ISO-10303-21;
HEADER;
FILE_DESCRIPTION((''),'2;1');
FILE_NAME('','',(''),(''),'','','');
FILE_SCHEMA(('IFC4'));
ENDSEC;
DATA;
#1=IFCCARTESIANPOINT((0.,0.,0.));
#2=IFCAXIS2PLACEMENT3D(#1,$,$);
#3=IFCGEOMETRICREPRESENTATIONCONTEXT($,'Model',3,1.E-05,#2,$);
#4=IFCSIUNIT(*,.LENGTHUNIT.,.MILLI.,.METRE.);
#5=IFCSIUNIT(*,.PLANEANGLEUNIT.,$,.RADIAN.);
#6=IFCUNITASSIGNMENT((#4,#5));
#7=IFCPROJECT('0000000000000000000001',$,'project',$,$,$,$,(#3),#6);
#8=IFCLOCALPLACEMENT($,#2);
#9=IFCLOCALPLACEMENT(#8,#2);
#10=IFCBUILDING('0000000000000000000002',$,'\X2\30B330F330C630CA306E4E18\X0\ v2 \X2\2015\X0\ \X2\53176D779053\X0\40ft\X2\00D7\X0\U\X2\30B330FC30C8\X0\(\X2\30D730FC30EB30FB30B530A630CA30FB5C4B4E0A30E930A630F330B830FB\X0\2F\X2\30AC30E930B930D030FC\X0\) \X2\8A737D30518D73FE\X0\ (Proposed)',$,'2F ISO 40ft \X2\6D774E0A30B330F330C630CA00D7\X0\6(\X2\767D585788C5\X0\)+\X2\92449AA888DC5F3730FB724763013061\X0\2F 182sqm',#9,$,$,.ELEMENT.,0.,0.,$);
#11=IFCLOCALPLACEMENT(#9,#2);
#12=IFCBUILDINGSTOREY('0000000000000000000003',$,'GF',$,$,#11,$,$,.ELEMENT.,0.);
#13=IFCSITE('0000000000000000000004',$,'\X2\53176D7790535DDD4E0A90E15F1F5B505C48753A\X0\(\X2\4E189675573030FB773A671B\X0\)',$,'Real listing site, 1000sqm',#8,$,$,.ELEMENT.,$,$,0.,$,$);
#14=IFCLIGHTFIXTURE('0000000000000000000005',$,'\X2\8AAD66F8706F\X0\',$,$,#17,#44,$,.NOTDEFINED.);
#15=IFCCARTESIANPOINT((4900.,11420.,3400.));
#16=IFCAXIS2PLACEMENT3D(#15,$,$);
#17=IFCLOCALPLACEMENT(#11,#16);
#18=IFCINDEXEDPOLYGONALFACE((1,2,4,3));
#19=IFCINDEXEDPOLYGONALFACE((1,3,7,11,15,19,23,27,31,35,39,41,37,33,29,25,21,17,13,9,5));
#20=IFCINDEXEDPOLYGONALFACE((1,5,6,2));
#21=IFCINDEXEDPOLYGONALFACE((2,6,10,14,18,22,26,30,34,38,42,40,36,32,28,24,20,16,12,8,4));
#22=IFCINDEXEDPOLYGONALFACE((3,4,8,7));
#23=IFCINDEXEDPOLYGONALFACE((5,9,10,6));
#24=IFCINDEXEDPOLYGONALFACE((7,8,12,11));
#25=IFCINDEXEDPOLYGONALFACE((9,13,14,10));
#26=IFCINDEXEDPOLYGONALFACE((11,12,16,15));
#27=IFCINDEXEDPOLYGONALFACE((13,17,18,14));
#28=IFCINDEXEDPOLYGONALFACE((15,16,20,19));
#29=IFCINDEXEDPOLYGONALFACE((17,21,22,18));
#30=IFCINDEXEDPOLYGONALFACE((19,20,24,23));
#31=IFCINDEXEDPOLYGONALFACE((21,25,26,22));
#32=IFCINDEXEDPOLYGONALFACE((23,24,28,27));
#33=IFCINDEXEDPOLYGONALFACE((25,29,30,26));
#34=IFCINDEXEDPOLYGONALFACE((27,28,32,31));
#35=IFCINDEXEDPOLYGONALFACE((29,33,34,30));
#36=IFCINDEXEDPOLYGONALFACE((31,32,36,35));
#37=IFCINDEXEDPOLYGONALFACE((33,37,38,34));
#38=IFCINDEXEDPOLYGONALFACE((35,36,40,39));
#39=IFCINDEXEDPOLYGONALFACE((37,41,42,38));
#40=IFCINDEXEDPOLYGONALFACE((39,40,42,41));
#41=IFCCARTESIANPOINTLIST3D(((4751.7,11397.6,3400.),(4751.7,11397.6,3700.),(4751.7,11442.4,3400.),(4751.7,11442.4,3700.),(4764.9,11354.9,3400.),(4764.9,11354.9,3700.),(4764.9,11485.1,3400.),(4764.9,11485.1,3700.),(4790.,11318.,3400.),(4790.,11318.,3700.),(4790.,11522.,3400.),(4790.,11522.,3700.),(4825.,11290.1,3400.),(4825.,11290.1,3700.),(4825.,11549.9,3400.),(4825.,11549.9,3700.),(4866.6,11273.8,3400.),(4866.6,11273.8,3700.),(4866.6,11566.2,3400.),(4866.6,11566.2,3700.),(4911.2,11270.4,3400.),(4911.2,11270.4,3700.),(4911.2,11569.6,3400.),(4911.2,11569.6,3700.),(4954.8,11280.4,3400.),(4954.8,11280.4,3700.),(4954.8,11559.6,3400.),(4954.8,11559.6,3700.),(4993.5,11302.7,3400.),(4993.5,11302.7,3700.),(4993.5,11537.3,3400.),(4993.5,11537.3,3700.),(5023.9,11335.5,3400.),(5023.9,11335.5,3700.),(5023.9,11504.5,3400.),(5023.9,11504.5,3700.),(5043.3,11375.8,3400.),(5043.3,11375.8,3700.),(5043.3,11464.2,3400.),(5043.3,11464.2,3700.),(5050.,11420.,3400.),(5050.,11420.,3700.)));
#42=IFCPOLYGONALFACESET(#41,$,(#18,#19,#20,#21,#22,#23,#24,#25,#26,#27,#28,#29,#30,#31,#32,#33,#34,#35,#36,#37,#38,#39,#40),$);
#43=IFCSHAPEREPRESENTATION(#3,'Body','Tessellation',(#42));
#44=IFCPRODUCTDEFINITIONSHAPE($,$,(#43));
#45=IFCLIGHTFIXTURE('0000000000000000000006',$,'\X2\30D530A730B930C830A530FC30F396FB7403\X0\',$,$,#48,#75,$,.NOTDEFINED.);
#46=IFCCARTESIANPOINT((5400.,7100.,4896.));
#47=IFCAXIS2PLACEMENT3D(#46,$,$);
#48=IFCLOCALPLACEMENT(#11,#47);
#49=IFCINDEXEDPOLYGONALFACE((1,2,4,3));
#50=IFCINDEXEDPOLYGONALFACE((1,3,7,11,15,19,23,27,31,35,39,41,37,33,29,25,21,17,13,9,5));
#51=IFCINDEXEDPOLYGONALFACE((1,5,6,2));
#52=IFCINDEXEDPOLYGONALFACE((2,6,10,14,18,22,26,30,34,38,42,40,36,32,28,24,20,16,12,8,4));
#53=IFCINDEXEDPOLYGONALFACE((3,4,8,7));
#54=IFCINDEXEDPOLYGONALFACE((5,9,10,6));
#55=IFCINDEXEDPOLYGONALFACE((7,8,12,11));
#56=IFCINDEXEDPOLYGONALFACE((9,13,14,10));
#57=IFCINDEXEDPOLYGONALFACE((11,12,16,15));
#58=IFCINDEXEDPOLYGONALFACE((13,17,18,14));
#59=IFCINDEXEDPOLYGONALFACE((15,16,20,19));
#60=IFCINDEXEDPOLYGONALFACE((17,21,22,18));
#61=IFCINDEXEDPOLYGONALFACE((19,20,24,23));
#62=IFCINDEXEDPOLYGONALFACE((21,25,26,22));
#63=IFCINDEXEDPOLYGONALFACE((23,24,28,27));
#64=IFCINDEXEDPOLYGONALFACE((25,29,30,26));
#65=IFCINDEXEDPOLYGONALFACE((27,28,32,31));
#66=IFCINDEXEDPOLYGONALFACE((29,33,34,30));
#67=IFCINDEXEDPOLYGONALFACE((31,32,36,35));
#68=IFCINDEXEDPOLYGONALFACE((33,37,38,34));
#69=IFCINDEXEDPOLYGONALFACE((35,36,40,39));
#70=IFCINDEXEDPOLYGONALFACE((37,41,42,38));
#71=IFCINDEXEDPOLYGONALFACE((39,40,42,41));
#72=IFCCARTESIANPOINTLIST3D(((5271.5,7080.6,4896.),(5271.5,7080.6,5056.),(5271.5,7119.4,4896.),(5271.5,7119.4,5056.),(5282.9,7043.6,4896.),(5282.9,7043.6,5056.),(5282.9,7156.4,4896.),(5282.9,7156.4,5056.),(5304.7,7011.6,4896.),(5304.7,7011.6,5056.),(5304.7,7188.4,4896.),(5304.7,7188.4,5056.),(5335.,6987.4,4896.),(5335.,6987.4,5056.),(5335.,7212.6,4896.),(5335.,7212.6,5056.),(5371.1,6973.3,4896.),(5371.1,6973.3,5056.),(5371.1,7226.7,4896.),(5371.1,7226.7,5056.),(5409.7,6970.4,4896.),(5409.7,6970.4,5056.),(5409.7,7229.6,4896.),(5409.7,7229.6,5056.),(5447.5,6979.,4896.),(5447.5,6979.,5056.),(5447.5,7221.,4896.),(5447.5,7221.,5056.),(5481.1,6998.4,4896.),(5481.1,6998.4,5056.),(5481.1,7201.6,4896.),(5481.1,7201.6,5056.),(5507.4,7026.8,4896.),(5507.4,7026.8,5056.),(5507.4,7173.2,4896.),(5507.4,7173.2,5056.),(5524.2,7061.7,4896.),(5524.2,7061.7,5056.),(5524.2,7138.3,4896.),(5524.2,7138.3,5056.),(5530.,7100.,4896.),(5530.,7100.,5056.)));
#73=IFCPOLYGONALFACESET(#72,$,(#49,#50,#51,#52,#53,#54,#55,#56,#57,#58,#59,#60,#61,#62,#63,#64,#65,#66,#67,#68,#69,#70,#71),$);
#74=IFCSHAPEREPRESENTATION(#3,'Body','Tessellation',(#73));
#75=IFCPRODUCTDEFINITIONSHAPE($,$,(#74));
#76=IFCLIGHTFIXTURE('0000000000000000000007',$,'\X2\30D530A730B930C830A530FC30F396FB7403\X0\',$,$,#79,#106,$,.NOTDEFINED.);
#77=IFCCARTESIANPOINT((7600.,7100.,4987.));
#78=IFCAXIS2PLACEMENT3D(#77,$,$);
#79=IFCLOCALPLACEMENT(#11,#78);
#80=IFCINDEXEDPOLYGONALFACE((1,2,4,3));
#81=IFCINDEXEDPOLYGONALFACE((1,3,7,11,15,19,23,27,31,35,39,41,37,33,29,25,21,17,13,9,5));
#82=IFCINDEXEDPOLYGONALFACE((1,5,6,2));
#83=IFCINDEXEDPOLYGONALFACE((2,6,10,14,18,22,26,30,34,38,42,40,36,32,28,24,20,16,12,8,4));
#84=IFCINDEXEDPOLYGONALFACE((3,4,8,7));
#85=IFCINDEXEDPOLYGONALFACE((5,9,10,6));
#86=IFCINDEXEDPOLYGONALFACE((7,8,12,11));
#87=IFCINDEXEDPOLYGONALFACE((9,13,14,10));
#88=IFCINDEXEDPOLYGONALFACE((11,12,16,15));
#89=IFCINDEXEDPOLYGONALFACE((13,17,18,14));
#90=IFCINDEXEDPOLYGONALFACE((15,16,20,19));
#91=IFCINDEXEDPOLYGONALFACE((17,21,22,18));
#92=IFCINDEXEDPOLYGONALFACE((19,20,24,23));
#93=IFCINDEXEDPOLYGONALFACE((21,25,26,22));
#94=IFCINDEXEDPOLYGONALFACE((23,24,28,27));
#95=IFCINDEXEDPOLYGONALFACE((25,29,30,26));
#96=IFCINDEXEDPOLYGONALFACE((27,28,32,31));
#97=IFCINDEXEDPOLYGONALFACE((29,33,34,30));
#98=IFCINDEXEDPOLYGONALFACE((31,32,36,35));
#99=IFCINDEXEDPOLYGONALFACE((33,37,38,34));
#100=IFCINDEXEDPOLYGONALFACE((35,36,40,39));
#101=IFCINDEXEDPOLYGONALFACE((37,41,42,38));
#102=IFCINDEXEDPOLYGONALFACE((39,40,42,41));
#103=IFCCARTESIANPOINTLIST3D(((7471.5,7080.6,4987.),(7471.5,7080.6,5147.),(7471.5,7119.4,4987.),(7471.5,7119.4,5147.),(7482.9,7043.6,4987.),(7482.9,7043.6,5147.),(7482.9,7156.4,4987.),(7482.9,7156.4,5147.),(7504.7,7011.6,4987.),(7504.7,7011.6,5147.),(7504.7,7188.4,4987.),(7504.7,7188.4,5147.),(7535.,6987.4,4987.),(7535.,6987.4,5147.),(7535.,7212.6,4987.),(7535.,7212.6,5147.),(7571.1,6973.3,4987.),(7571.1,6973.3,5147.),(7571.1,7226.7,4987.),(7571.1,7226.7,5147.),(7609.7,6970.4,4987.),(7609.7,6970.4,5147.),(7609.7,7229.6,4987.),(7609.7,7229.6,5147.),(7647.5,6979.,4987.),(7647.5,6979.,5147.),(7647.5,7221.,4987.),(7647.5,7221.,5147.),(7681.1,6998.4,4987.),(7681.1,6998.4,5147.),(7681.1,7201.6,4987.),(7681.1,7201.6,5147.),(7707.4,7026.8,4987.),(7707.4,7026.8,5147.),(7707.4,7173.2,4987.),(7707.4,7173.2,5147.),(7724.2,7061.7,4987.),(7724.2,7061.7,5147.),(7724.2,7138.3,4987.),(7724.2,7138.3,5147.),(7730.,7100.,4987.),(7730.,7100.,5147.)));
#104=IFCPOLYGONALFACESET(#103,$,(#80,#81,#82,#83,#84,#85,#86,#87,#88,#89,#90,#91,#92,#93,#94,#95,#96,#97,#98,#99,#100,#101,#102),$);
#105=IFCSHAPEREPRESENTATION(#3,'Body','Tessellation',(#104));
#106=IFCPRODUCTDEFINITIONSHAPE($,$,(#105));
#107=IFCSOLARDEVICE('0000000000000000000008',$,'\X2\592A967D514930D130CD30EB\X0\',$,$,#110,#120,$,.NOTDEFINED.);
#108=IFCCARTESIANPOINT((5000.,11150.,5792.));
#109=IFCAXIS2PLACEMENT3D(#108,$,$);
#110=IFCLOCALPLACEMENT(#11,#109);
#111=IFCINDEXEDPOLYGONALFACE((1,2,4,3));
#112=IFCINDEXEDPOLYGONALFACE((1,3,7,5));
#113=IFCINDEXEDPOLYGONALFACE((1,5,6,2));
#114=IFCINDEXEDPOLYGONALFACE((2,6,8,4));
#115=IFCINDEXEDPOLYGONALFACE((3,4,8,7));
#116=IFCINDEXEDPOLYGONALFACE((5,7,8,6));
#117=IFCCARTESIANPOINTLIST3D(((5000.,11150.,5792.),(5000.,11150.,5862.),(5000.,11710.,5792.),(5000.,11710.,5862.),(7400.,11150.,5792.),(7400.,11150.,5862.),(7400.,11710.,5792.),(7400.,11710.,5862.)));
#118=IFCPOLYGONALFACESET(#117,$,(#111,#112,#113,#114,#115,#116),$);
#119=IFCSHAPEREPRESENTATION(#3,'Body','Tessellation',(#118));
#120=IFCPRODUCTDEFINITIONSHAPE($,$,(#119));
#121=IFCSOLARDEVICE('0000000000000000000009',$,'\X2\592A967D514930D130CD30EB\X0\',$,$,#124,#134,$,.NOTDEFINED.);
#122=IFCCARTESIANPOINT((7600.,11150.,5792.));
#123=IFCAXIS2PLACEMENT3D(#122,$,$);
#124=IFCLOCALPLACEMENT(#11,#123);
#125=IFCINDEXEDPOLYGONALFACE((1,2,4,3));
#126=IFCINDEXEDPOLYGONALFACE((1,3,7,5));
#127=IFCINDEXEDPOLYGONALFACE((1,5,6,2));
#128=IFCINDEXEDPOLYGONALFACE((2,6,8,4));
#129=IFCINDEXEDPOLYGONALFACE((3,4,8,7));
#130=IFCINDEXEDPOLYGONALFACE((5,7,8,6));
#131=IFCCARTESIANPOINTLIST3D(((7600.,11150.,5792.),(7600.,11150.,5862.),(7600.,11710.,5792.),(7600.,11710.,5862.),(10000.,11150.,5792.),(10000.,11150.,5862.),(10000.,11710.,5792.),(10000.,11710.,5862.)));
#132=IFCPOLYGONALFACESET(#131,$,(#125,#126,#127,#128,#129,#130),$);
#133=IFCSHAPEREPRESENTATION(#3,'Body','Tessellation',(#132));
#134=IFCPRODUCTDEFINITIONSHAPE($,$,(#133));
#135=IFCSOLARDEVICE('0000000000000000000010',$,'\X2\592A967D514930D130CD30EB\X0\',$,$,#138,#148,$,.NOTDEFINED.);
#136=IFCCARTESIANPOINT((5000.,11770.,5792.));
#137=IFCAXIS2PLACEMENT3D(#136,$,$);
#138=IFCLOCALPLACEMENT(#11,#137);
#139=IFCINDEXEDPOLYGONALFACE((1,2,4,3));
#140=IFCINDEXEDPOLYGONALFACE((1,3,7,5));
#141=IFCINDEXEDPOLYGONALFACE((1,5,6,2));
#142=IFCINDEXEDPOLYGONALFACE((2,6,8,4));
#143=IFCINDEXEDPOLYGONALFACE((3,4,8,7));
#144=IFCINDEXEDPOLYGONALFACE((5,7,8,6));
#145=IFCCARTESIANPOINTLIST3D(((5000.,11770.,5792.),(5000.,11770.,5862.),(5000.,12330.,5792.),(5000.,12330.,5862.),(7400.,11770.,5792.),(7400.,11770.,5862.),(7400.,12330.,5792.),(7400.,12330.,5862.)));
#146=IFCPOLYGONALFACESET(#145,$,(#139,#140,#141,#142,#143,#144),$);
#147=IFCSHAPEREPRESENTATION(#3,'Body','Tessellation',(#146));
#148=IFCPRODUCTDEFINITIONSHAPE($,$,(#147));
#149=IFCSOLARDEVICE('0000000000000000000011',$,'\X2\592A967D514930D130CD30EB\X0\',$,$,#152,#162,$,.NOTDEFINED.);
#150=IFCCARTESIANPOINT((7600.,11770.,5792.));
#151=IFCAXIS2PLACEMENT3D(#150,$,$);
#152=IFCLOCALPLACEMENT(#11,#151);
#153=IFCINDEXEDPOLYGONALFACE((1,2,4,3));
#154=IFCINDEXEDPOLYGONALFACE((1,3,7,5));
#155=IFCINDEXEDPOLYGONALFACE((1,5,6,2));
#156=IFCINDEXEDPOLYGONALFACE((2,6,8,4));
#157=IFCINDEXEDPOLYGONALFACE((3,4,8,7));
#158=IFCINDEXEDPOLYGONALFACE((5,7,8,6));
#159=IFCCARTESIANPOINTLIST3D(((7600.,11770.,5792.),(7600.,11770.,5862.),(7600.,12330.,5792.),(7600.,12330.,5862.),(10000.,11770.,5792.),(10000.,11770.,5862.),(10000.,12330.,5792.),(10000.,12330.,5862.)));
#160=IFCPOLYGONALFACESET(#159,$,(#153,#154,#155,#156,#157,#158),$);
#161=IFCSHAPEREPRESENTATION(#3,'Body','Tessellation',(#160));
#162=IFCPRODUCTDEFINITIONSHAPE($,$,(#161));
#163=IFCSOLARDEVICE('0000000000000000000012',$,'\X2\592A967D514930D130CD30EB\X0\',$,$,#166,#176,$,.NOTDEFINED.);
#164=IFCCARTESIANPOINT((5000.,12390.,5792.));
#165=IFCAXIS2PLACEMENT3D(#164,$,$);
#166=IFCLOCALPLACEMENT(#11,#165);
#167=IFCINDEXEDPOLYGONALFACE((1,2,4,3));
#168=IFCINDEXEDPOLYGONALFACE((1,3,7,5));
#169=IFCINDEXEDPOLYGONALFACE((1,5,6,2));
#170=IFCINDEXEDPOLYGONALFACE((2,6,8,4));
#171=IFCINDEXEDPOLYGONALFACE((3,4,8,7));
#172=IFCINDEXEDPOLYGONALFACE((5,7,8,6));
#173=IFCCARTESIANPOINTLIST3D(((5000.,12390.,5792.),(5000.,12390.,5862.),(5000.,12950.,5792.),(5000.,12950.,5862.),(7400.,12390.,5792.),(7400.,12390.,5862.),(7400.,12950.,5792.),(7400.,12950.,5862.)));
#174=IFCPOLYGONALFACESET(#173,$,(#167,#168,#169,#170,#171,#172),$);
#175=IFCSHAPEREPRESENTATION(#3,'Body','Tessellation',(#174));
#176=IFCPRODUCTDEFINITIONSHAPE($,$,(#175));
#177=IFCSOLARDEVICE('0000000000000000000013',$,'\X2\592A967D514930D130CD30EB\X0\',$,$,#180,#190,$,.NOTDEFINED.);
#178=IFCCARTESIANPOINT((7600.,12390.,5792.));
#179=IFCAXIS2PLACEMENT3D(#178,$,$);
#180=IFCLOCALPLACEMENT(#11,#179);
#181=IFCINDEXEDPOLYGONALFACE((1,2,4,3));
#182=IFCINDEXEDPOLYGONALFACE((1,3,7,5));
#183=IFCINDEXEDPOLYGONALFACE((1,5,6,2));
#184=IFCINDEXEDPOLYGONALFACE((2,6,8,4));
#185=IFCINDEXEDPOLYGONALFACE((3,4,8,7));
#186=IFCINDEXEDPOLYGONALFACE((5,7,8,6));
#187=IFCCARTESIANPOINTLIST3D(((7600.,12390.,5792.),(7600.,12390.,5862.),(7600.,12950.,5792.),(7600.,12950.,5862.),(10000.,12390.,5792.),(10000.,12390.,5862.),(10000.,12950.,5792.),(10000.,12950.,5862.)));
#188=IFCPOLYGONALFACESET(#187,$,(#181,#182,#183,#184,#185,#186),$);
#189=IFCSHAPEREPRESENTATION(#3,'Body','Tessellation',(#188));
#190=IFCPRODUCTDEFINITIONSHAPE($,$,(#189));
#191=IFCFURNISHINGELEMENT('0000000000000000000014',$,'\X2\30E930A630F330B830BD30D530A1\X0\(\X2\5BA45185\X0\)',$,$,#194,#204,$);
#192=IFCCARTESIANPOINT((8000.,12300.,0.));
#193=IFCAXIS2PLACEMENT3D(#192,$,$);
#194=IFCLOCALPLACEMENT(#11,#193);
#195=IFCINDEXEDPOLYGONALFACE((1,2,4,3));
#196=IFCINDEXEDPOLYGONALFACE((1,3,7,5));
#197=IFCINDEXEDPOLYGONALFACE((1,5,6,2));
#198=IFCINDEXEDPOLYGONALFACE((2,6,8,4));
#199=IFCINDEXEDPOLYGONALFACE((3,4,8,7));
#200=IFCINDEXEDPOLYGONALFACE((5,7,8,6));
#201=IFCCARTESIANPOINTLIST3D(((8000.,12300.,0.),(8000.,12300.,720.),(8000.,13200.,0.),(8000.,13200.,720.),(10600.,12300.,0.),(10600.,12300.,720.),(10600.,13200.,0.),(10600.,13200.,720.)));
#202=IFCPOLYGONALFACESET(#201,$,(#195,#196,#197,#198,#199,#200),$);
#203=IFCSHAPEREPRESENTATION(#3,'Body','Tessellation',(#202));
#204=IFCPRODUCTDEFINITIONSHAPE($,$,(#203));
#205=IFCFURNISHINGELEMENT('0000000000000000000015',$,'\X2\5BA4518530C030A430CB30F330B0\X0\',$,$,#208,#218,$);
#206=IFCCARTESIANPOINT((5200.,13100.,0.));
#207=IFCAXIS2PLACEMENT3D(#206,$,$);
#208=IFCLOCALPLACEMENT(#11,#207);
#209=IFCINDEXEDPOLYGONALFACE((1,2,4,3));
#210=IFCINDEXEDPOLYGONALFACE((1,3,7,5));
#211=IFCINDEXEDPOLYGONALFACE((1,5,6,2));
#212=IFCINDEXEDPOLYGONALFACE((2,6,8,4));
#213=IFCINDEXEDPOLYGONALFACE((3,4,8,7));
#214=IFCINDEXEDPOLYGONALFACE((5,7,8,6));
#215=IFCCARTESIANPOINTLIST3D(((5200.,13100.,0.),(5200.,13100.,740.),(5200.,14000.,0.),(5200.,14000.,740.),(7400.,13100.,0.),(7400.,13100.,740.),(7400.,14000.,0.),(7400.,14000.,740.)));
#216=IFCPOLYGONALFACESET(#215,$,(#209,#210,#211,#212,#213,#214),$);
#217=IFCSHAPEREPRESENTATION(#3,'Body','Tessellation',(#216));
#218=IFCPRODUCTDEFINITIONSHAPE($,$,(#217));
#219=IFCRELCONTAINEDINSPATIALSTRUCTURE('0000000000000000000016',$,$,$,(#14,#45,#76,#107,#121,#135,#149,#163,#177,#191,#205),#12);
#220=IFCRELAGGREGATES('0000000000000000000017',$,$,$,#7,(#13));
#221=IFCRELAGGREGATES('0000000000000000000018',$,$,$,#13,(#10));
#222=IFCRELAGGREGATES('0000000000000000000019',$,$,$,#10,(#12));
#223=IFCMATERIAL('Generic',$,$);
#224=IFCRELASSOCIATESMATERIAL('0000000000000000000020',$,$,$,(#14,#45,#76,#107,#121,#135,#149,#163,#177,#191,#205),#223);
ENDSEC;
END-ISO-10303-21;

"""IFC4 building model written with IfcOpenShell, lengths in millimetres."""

from ifc_helpers import new_model, si_unit, frame, frame_2d, origin, origin_2d, place, context, project, spatial, rectangle, circle, extrude, material, element, save


model = new_model("IFC4")

# Units and contexts
model_context = context("Model", 3, precision=1e-05, world=origin())
ifc_project = project(units=[si_unit("LENGTHUNIT", "METRE", prefix="MILLI"), si_unit("PLANEANGLEUNIT", "RADIAN")], contexts=[model_context])

# Site, building, storey
site_placement = place(None, origin())
site = spatial("IfcSite", under=ifc_project, at=site_placement, Name="北海道川上郡弟子屈町(丘陵地・眺望)", ObjectType="Real listing site, 1000sqm", CompositionType="ELEMENT", RefElevation=0.0)
building_placement = place(site_placement, origin())
building = spatial("IfcBuilding", under=site, at=building_placement, Name="コンテナの丘 v2 ― 北海道40ft×Uコート(プール・サウナ・屋上ラウンジ・2Fガラスバー) 詳細再現 (Proposed)", ObjectType="2F ISO 40ft 海上コンテナ×6(白塗装)+鉄骨補強・片持ち2F 182sqm", CompositionType="ELEMENT", ElevationOfRefHeight=0.0, ElevationOfTerrain=0.0)
storey_placement = place(building_placement, origin())
storey = spatial("IfcBuildingStorey", under=building, at=storey_placement, Name="GF", CompositionType="ELEMENT", Elevation=0.0)

# Shared definitions
ifc_material = material(Name="Generic")

# Light fixtures
light_fixture_1_placement = place(storey_placement, frame((4900.0, 11420.0, 3400.0)))
element("IfcLightFixture", 1, at=light_fixture_1_placement, inside=storey, material=ifc_material, Name="読書灯", PredefinedType="NOTDEFINED", context=model_context, shape_type="SweptSolid", body=[
    extrude(circle(Radius=150.0, at=origin_2d()), frame((4900.0, 11420.0, 3400.0)), (0.0, 0.0, 1.0), 300.0),
])
light_fixture_2_placement = place(storey_placement, frame((5400.0, 7100.0, 4896.0)))
element("IfcLightFixture", 2, at=light_fixture_2_placement, inside=storey, material=ifc_material, Name="フェストゥーン電球", PredefinedType="NOTDEFINED", context=model_context, shape_type="SweptSolid", body=[
    extrude(circle(Radius=130.0, at=origin_2d()), frame((5400.0, 7100.0, 4896.0)), (0.0, 0.0, 1.0), 160.0),
])
light_fixture_3_placement = place(storey_placement, frame((7600.0, 7100.0, 4987.0)))
element("IfcLightFixture", 3, at=light_fixture_3_placement, inside=storey, material=ifc_material, Name="フェストゥーン電球", PredefinedType="NOTDEFINED", context=model_context, shape_type="SweptSolid", body=[
    extrude(circle(Radius=130.0, at=origin_2d()), frame((7600.0, 7100.0, 4987.0)), (0.0, 0.0, 1.0), 160.0),
])

# Solar devices
solar_device_1_placement = place(storey_placement, frame((5000.0, 11150.0, 5792.0)))
element("IfcSolarDevice", 4, at=solar_device_1_placement, inside=storey, material=ifc_material, Name="太陽光パネル", PredefinedType="NOTDEFINED", context=model_context, shape_type="SweptSolid", body=[
    extrude(rectangle(XDim=2400.0, YDim=560.0, at=frame_2d((1200.0, 280.0))), frame((5000.0, 11150.0, 5792.0)), (0.0, 0.0, 1.0), 70.0),
])
solar_device_2_placement = place(storey_placement, frame((7600.0, 11150.0, 5792.0)))
element("IfcSolarDevice", 5, at=solar_device_2_placement, inside=storey, material=ifc_material, Name="太陽光パネル", PredefinedType="NOTDEFINED", context=model_context, shape_type="SweptSolid", body=[
    extrude(rectangle(XDim=2400.0, YDim=560.0, at=frame_2d((1200.0, 280.0))), frame((7600.0, 11150.0, 5792.0)), (0.0, 0.0, 1.0), 70.0),
])
solar_device_3_placement = place(storey_placement, frame((5000.0, 11770.0, 5792.0)))
element("IfcSolarDevice", 6, at=solar_device_3_placement, inside=storey, material=ifc_material, Name="太陽光パネル", PredefinedType="NOTDEFINED", context=model_context, shape_type="SweptSolid", body=[
    extrude(rectangle(XDim=2400.0, YDim=560.0, at=frame_2d((1200.0, 280.0))), frame((5000.0, 11770.0, 5792.0)), (0.0, 0.0, 1.0), 70.0),
])
solar_device_4_placement = place(storey_placement, frame((7600.0, 11770.0, 5792.0)))
element("IfcSolarDevice", 7, at=solar_device_4_placement, inside=storey, material=ifc_material, Name="太陽光パネル", PredefinedType="NOTDEFINED", context=model_context, shape_type="SweptSolid", body=[
    extrude(rectangle(XDim=2400.0, YDim=560.0, at=frame_2d((1200.0, 280.0))), frame((7600.0, 11770.0, 5792.0)), (0.0, 0.0, 1.0), 70.0),
])
solar_device_5_placement = place(storey_placement, frame((5000.0, 12390.0, 5792.0)))
element("IfcSolarDevice", 8, at=solar_device_5_placement, inside=storey, material=ifc_material, Name="太陽光パネル", PredefinedType="NOTDEFINED", context=model_context, shape_type="SweptSolid", body=[
    extrude(rectangle(XDim=2400.0, YDim=560.0, at=frame_2d((1200.0, 280.0))), frame((5000.0, 12390.0, 5792.0)), (0.0, 0.0, 1.0), 70.0),
])
solar_device_6_placement = place(storey_placement, frame((7600.0, 12390.0, 5792.0)))
element("IfcSolarDevice", 9, at=solar_device_6_placement, inside=storey, material=ifc_material, Name="太陽光パネル", PredefinedType="NOTDEFINED", context=model_context, shape_type="SweptSolid", body=[
    extrude(rectangle(XDim=2400.0, YDim=560.0, at=frame_2d((1200.0, 280.0))), frame((7600.0, 12390.0, 5792.0)), (0.0, 0.0, 1.0), 70.0),
])

# Furnishing elements
furnishing_1_placement = place(storey_placement, frame((8000.0, 12300.0, 0.0)))
element("IfcFurnishingElement", 10, at=furnishing_1_placement, inside=storey, material=ifc_material, Name="ラウンジソファ(室内)", context=model_context, shape_type="SweptSolid", body=[
    extrude(rectangle(XDim=2600.0, YDim=900.0, at=frame_2d((1300.0, 450.0))), frame((8000.0, 12300.0, 0.0)), (0.0, 0.0, 1.0), 720.0),
])
furnishing_2_placement = place(storey_placement, frame((5200.0, 13100.0, 0.0)))
element("IfcFurnishingElement", 11, at=furnishing_2_placement, inside=storey, material=ifc_material, Name="室内ダイニング", context=model_context, shape_type="SweptSolid", body=[
    extrude(rectangle(XDim=2200.0, YDim=900.0, at=frame_2d((1100.0, 450.0))), frame((5200.0, 13100.0, 0.0)), (0.0, 0.0, 1.0), 740.0),
])

save(model, "model.ifc")
